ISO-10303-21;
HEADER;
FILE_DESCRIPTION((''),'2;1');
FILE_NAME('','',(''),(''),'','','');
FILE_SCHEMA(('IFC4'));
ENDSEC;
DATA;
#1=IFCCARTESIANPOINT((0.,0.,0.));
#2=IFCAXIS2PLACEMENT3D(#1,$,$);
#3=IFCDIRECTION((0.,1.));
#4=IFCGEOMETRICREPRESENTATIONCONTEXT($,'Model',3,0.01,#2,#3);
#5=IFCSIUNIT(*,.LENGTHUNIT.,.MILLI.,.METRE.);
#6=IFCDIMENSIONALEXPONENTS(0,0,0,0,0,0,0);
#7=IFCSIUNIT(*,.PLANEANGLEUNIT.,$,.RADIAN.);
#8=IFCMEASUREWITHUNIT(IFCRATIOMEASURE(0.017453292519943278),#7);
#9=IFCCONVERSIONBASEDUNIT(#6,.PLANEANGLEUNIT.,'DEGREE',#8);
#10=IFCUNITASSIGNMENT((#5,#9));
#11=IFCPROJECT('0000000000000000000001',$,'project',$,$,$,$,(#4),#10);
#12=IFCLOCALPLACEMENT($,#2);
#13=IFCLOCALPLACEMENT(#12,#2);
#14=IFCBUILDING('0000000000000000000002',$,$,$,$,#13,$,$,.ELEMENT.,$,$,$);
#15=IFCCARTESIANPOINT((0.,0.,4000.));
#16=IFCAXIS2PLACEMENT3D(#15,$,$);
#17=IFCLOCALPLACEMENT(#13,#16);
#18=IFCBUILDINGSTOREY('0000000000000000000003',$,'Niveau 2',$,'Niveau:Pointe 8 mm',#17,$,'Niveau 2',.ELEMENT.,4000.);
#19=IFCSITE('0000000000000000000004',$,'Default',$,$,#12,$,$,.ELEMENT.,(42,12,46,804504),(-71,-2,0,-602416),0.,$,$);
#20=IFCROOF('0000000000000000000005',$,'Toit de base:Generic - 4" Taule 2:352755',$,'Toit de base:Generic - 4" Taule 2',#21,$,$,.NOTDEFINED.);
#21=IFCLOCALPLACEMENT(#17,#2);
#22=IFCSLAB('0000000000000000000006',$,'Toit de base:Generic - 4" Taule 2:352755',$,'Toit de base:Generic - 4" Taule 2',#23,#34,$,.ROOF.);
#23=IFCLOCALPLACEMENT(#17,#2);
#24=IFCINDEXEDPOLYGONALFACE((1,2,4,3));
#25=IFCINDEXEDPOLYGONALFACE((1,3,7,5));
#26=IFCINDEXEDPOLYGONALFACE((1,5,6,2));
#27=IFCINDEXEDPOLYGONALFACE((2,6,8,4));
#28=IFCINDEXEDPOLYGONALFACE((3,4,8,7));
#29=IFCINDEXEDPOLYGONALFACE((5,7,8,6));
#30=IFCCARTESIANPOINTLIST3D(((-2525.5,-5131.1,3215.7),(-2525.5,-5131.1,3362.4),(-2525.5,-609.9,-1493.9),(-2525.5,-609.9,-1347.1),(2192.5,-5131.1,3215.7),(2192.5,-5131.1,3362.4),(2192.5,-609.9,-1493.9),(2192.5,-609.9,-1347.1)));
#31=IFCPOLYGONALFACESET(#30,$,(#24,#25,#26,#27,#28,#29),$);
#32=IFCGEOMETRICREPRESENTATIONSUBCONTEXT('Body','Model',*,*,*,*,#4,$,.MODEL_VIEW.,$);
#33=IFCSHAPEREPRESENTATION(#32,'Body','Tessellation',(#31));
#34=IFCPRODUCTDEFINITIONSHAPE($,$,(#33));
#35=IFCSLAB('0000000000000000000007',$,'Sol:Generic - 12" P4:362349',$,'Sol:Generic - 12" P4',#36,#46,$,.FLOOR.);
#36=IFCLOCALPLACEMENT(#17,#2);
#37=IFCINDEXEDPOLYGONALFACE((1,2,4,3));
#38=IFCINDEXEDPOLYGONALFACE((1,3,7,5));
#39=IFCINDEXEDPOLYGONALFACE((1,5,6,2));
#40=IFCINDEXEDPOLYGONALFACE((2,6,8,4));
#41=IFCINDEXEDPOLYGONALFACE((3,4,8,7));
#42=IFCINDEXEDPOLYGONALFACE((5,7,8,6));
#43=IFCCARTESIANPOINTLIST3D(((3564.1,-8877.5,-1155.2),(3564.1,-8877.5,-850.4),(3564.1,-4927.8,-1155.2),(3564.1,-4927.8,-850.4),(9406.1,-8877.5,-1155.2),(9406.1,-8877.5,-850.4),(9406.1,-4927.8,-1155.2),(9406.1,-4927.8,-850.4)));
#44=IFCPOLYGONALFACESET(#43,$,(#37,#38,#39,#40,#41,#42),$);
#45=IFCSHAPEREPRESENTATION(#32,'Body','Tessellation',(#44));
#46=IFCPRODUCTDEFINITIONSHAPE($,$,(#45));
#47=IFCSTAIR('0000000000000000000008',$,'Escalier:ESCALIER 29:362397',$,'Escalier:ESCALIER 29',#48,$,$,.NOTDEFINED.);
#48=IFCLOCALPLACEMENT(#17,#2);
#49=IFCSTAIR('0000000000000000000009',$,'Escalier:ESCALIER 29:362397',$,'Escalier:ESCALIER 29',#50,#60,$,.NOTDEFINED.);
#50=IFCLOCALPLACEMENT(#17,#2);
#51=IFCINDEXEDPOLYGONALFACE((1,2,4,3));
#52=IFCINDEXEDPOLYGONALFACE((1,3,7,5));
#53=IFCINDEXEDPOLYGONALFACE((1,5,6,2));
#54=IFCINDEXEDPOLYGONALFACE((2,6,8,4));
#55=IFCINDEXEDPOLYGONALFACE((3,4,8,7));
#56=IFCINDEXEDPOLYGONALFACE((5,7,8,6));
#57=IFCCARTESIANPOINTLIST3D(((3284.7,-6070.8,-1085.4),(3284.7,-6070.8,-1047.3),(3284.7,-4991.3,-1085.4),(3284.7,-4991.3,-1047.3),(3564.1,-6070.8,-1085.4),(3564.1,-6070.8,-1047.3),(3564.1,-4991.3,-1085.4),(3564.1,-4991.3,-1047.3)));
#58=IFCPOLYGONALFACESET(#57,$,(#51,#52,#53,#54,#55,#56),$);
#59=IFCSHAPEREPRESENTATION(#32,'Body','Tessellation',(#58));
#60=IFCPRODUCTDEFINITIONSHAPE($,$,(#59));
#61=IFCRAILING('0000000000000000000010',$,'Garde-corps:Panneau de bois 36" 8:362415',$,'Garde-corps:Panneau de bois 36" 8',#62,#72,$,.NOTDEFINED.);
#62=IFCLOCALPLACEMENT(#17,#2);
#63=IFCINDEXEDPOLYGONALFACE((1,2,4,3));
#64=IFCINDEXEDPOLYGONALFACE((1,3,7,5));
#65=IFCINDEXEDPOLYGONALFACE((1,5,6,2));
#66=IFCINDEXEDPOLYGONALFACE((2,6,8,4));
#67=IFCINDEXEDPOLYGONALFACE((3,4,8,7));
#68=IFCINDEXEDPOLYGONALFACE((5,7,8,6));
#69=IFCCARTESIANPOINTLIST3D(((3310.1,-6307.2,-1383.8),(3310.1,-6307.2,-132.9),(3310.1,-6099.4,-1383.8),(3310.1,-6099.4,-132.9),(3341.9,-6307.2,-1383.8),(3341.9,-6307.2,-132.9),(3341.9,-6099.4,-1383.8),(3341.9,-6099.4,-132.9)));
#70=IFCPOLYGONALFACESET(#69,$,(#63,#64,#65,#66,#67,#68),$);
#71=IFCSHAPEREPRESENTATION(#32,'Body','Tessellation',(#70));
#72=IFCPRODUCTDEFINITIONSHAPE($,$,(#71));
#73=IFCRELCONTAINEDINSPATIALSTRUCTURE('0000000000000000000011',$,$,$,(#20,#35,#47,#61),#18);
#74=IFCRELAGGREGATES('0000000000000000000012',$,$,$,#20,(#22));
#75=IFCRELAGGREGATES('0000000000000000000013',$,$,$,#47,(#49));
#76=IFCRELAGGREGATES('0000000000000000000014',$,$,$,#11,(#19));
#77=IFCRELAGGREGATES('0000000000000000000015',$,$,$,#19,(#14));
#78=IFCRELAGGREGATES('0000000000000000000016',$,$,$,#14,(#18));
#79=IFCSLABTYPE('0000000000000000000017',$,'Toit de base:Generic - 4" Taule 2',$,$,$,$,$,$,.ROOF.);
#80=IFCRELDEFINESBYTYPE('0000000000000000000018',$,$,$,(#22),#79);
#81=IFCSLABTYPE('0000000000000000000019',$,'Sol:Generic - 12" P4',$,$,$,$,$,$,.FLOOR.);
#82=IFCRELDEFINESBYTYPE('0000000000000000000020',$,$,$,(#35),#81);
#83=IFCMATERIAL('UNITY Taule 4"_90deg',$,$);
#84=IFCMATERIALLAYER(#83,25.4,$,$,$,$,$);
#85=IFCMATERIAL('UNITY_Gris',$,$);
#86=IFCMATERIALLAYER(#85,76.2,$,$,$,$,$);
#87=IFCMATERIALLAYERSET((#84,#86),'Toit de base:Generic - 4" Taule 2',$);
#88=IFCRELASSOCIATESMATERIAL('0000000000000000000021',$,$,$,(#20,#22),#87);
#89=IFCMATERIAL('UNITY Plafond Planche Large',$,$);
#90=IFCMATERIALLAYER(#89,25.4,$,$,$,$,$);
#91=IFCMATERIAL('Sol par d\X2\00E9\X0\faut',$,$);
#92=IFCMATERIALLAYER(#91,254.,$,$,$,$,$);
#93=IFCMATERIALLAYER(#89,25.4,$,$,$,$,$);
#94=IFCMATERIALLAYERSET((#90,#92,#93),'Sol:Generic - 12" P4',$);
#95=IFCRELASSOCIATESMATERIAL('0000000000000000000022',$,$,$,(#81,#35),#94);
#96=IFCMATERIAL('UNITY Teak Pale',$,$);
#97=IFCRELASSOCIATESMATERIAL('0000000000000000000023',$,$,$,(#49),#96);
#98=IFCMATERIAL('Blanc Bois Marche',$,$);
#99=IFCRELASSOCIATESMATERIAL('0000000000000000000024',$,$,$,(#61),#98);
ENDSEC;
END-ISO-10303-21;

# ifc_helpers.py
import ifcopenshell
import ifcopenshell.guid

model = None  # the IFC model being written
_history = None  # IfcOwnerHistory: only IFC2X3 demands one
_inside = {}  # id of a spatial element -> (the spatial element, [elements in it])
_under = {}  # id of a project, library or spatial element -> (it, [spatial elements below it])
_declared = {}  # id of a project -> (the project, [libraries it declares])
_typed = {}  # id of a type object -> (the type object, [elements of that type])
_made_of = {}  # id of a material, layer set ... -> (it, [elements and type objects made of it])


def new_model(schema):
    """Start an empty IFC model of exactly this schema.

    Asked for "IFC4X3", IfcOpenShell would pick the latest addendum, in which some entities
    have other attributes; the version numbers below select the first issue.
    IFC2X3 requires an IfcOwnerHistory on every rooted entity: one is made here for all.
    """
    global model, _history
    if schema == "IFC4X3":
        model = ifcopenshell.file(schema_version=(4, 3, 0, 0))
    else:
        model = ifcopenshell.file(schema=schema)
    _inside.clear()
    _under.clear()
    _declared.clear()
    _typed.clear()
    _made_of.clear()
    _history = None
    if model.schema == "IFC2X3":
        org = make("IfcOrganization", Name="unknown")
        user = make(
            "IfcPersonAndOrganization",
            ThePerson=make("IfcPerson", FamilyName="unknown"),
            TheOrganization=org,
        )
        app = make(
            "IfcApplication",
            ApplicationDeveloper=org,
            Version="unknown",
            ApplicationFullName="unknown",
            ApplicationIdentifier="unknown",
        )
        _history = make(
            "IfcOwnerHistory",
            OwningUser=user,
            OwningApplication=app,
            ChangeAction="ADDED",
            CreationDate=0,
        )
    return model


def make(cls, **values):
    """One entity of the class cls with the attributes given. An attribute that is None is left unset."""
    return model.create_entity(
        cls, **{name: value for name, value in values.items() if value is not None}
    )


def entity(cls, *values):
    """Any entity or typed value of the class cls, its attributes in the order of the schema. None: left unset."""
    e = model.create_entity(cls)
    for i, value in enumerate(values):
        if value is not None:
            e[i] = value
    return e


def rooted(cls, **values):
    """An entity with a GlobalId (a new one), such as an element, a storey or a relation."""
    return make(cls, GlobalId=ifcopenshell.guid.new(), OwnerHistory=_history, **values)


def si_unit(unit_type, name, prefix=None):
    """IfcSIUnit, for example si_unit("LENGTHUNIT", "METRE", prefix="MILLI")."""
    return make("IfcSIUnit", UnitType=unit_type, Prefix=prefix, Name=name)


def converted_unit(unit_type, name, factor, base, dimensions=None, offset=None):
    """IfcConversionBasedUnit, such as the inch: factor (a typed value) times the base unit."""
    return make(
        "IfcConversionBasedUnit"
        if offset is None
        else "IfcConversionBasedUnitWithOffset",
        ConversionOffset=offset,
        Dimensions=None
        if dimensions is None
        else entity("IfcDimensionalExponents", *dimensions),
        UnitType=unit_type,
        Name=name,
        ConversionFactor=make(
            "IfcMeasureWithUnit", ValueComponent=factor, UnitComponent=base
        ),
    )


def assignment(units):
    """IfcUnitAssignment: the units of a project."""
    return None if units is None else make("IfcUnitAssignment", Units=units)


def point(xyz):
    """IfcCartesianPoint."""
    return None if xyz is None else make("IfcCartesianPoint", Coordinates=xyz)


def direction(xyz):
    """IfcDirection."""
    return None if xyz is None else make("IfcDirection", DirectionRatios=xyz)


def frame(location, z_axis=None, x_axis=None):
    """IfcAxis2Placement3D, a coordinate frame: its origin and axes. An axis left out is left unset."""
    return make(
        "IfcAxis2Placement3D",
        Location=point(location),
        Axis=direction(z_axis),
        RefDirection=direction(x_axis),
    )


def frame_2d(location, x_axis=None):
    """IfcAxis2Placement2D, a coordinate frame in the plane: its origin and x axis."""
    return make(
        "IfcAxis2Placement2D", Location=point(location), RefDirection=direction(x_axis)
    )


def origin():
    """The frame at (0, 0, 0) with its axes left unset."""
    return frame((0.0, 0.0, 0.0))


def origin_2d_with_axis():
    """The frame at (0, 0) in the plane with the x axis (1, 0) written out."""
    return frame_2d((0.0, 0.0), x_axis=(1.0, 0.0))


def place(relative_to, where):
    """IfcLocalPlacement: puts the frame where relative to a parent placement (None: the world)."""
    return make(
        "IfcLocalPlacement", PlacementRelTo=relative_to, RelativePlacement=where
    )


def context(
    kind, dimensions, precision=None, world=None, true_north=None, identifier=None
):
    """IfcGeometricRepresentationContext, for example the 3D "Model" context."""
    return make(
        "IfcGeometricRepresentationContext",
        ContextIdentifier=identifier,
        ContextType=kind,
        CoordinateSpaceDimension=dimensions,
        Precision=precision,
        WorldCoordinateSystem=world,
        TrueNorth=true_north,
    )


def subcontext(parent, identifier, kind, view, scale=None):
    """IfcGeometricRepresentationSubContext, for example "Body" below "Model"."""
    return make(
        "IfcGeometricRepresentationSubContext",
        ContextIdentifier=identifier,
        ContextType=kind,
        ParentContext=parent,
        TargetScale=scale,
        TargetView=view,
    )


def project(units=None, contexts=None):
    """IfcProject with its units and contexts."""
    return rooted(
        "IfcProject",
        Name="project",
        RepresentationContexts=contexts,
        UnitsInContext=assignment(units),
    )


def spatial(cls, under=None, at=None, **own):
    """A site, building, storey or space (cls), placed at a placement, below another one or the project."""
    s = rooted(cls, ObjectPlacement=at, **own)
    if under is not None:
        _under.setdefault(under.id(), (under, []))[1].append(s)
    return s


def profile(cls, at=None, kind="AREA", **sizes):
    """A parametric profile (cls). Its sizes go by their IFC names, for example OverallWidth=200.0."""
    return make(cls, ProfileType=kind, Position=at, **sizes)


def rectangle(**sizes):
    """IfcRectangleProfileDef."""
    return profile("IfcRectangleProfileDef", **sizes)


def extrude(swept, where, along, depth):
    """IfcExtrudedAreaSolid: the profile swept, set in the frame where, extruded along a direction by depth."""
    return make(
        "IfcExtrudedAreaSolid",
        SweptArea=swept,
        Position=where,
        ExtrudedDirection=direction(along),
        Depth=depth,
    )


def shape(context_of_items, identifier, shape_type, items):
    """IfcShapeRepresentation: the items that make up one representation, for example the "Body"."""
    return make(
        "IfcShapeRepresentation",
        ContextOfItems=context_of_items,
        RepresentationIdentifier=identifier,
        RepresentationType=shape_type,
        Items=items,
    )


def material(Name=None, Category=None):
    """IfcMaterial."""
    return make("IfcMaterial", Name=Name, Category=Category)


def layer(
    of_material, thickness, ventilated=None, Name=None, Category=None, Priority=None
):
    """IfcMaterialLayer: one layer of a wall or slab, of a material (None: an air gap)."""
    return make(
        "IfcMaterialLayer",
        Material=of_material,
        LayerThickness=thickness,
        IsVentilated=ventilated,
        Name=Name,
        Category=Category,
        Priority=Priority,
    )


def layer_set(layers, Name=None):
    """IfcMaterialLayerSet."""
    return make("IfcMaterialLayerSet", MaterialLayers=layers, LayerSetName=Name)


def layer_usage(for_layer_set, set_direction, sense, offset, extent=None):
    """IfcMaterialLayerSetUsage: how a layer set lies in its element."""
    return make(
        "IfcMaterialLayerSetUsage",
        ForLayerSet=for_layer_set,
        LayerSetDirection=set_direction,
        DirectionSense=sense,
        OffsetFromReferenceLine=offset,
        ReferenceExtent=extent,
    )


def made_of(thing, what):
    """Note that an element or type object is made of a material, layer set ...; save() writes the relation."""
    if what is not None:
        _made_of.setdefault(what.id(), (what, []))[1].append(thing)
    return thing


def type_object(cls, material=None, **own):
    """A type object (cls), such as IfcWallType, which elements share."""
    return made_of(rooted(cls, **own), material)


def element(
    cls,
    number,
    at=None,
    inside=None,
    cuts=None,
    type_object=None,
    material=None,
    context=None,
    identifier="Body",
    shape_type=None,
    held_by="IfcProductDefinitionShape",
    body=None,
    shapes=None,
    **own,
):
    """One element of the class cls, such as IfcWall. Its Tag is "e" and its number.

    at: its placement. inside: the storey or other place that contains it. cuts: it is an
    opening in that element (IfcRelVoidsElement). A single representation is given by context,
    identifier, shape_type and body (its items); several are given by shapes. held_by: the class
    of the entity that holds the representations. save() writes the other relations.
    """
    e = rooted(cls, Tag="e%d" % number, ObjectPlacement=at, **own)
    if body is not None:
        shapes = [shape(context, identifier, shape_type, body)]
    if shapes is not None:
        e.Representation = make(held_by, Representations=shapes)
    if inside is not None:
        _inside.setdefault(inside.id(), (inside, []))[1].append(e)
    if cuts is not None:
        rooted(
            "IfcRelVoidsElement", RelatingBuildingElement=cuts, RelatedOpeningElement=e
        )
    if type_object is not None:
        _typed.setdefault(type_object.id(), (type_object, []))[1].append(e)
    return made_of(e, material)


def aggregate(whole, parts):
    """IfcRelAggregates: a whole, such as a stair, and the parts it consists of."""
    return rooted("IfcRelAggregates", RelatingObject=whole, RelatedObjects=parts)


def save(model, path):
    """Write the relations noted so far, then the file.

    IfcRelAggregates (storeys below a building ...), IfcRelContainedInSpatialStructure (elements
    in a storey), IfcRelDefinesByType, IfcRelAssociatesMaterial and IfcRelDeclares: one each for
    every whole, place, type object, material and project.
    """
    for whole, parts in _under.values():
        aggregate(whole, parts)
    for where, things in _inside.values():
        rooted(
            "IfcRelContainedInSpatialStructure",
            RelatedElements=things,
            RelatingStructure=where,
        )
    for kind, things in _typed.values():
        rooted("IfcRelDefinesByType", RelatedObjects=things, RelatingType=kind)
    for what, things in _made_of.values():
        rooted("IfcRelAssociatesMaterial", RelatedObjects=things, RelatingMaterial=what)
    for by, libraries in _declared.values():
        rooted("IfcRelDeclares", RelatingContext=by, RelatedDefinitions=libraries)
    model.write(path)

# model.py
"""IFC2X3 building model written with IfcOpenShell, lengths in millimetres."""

from ifc_helpers import new_model, entity, si_unit, converted_unit, direction, frame, frame_2d, origin, origin_2d_with_axis, place, context, subcontext, project, spatial, rectangle, extrude, material, layer, layer_set, layer_usage, type_object, element, aggregate, save


model = new_model("IFC2X3")

# Units and contexts
model_context = context("Model", 3, precision=0.01, world=origin(), true_north=direction((0.0, 1.0)))
body_context = subcontext(model_context, "Body", "Model", "MODEL_VIEW")
ifc_project = project(units=[si_unit("LENGTHUNIT", "METRE", prefix="MILLI"), converted_unit("PLANEANGLEUNIT", "DEGREE", entity("IfcRatioMeasure", 0.017453292519943278), si_unit("PLANEANGLEUNIT", "RADIAN"), dimensions=[0, 0, 0, 0, 0, 0, 0])], contexts=[model_context])

# Site, building, storey
site_placement = place(None, origin())
site = spatial("IfcSite", under=ifc_project, at=site_placement, Name="Default", CompositionType="ELEMENT", RefLatitude=(42, 12, 46, 804504), RefLongitude=(-71, -2, 0, -602416), RefElevation=0.0)
building_placement = place(site_placement, origin())
building = spatial("IfcBuilding", under=site, at=building_placement, CompositionType="ELEMENT")
storey_placement = place(building_placement, frame((0.0, 0.0, 4000.0)))
storey = spatial("IfcBuildingStorey", under=building, at=storey_placement, Name="Niveau 2", ObjectType="Niveau:Pointe 8 mm", LongName="Niveau 2", CompositionType="ELEMENT", Elevation=4000.0)

# Roof, slab
ifc_material_1 = material(Name="UNITY Taule 4\"_90deg")
ifc_layer_1 = layer(ifc_material_1, 25.4)
ifc_material_2 = material(Name="UNITY_Gris")
ifc_layer_2 = layer(ifc_material_2, 76.2)
ifc_layer_set_1 = layer_set([ifc_layer_1, ifc_layer_2], Name="Toit de base:Generic - 4\" Taule 2")
roof_1_placement = place(storey_placement, frame((-2525.5, -5131.1, -1493.9)))
roof_1 = element("IfcRoof", 1, at=roof_1_placement, inside=storey, material=ifc_layer_set_1, Name="Toit de base:Generic - 4\" Taule 2:352755", ObjectType="Toit de base:Generic - 4\" Taule 2", ShapeType="NOTDEFINED")
slab_type_1 = type_object("IfcSlabType", Name="Toit de base:Generic - 4\" Taule 2", PredefinedType="ROOF")
slab_1_placement = place(roof_1_placement, origin())
slab_1 = element("IfcSlab", 2, at=slab_1_placement, type_object=slab_type_1, material=ifc_layer_set_1, Name="Toit de base:Generic - 4\" Taule 2:352755", ObjectType="Toit de base:Generic - 4\" Taule 2", PredefinedType="ROOF", context=body_context, shape_type="SweptSolid", body=[
    extrude(rectangle(XDim=4718.1, YDim=6528.5, at=frame_2d((0.0, 0.0), x_axis=(-1.0, 0.0))), frame((2359.0, 2260.6, 2354.8), z_axis=(0.0, 0.721387, 0.692532), x_axis=(1.0, 0.0, 0.0)), (0.0, -0.721387, 0.692532), 146.7),
])
aggregate(roof_1, [slab_1])

# Slab
ifc_material_3 = material(Name="UNITY Plafond Planche Large")
ifc_layer_3 = layer(ifc_material_3, 25.4)
ifc_material_4 = material(Name="Sol par défaut")
ifc_layer_4 = layer(ifc_material_4, 254.0)
ifc_layer_5 = layer(ifc_material_3, 25.4)
ifc_layer_set_2 = layer_set([ifc_layer_3, ifc_layer_4, ifc_layer_5], Name="Sol:Generic - 12\" P4")
ifc_layer_usage_1 = layer_usage(ifc_layer_set_2, "AXIS3", "POSITIVE", 0.0)
slab_type_2 = type_object("IfcSlabType", Name="Sol:Generic - 12\" P4", PredefinedType="FLOOR", material=ifc_layer_set_2)
slab_2_placement = place(storey_placement, origin())
element("IfcSlab", 3, at=slab_2_placement, inside=storey, type_object=slab_type_2, material=ifc_layer_usage_1, Name="Sol:Generic - 12\" P4:362349", ObjectType="Sol:Generic - 12\" P4", PredefinedType="FLOOR", context=body_context, shape_type="SweptSolid", body=[
    extrude(rectangle(XDim=3949.7, YDim=5842.0, at=origin_2d_with_axis()), frame((6485.1, -6902.7, -850.4), z_axis=(0.0, 0.0, -1.0), x_axis=(0.0, 1.0, 0.0)), (0.0, 0.0, 1.0), 304.8),
])

# Stairs
stair_1_placement = place(storey_placement, origin())
stair_1 = element("IfcStair", 4, at=stair_1_placement, inside=storey, Name="Escalier:ESCALIER 29:362397", ObjectType="Escalier:ESCALIER 29", ShapeType="NOTDEFINED")
ifc_material_5 = material(Name="UNITY Teak Pale")
stair_2_placement = place(stair_1_placement, origin())
stair_2 = element("IfcStair", 5, at=stair_2_placement, material=ifc_material_5, Name="Escalier:ESCALIER 29:362397", ObjectType="Escalier:ESCALIER 29", ShapeType="NOTDEFINED", context=body_context, shape_type="SweptSolid", body=[
    extrude(rectangle(XDim=279.4, YDim=1079.5, at=frame_2d((0.0, 0.0), x_axis=(1.0, 0.0))), frame((3424.4, -5531.1, -1085.4), z_axis=(0.0, 0.0, 1.0), x_axis=(-1.0, 0.0, 0.0)), (0.0, 0.0, 1.0), 38.1),
])

# Railing
ifc_material_6 = material(Name="Blanc Bois Marche")
aggregate(stair_1, [stair_2])
railing_1_placement = place(storey_placement, origin())
element("IfcRailing", 6, at=railing_1_placement, inside=storey, material=ifc_material_6, Name="Garde-corps:Panneau de bois 36\" 8:362415", ObjectType="Garde-corps:Panneau de bois 36\" 8", PredefinedType="NOTDEFINED", context=body_context, shape_type="SweptSolid", body=[
    extrude(rectangle(XDim=207.8, YDim=31.7, at=frame_2d((0.0, 0.0), x_axis=(1.0, 0.0))), frame((3326.0, -6203.3, -1383.8), z_axis=(0.0, 0.0, 1.0), x_axis=(0.0, 1.0, 0.0)), (0.0, 0.0, 1.0), 1250.9),
])

save(model, "model.ifc")
